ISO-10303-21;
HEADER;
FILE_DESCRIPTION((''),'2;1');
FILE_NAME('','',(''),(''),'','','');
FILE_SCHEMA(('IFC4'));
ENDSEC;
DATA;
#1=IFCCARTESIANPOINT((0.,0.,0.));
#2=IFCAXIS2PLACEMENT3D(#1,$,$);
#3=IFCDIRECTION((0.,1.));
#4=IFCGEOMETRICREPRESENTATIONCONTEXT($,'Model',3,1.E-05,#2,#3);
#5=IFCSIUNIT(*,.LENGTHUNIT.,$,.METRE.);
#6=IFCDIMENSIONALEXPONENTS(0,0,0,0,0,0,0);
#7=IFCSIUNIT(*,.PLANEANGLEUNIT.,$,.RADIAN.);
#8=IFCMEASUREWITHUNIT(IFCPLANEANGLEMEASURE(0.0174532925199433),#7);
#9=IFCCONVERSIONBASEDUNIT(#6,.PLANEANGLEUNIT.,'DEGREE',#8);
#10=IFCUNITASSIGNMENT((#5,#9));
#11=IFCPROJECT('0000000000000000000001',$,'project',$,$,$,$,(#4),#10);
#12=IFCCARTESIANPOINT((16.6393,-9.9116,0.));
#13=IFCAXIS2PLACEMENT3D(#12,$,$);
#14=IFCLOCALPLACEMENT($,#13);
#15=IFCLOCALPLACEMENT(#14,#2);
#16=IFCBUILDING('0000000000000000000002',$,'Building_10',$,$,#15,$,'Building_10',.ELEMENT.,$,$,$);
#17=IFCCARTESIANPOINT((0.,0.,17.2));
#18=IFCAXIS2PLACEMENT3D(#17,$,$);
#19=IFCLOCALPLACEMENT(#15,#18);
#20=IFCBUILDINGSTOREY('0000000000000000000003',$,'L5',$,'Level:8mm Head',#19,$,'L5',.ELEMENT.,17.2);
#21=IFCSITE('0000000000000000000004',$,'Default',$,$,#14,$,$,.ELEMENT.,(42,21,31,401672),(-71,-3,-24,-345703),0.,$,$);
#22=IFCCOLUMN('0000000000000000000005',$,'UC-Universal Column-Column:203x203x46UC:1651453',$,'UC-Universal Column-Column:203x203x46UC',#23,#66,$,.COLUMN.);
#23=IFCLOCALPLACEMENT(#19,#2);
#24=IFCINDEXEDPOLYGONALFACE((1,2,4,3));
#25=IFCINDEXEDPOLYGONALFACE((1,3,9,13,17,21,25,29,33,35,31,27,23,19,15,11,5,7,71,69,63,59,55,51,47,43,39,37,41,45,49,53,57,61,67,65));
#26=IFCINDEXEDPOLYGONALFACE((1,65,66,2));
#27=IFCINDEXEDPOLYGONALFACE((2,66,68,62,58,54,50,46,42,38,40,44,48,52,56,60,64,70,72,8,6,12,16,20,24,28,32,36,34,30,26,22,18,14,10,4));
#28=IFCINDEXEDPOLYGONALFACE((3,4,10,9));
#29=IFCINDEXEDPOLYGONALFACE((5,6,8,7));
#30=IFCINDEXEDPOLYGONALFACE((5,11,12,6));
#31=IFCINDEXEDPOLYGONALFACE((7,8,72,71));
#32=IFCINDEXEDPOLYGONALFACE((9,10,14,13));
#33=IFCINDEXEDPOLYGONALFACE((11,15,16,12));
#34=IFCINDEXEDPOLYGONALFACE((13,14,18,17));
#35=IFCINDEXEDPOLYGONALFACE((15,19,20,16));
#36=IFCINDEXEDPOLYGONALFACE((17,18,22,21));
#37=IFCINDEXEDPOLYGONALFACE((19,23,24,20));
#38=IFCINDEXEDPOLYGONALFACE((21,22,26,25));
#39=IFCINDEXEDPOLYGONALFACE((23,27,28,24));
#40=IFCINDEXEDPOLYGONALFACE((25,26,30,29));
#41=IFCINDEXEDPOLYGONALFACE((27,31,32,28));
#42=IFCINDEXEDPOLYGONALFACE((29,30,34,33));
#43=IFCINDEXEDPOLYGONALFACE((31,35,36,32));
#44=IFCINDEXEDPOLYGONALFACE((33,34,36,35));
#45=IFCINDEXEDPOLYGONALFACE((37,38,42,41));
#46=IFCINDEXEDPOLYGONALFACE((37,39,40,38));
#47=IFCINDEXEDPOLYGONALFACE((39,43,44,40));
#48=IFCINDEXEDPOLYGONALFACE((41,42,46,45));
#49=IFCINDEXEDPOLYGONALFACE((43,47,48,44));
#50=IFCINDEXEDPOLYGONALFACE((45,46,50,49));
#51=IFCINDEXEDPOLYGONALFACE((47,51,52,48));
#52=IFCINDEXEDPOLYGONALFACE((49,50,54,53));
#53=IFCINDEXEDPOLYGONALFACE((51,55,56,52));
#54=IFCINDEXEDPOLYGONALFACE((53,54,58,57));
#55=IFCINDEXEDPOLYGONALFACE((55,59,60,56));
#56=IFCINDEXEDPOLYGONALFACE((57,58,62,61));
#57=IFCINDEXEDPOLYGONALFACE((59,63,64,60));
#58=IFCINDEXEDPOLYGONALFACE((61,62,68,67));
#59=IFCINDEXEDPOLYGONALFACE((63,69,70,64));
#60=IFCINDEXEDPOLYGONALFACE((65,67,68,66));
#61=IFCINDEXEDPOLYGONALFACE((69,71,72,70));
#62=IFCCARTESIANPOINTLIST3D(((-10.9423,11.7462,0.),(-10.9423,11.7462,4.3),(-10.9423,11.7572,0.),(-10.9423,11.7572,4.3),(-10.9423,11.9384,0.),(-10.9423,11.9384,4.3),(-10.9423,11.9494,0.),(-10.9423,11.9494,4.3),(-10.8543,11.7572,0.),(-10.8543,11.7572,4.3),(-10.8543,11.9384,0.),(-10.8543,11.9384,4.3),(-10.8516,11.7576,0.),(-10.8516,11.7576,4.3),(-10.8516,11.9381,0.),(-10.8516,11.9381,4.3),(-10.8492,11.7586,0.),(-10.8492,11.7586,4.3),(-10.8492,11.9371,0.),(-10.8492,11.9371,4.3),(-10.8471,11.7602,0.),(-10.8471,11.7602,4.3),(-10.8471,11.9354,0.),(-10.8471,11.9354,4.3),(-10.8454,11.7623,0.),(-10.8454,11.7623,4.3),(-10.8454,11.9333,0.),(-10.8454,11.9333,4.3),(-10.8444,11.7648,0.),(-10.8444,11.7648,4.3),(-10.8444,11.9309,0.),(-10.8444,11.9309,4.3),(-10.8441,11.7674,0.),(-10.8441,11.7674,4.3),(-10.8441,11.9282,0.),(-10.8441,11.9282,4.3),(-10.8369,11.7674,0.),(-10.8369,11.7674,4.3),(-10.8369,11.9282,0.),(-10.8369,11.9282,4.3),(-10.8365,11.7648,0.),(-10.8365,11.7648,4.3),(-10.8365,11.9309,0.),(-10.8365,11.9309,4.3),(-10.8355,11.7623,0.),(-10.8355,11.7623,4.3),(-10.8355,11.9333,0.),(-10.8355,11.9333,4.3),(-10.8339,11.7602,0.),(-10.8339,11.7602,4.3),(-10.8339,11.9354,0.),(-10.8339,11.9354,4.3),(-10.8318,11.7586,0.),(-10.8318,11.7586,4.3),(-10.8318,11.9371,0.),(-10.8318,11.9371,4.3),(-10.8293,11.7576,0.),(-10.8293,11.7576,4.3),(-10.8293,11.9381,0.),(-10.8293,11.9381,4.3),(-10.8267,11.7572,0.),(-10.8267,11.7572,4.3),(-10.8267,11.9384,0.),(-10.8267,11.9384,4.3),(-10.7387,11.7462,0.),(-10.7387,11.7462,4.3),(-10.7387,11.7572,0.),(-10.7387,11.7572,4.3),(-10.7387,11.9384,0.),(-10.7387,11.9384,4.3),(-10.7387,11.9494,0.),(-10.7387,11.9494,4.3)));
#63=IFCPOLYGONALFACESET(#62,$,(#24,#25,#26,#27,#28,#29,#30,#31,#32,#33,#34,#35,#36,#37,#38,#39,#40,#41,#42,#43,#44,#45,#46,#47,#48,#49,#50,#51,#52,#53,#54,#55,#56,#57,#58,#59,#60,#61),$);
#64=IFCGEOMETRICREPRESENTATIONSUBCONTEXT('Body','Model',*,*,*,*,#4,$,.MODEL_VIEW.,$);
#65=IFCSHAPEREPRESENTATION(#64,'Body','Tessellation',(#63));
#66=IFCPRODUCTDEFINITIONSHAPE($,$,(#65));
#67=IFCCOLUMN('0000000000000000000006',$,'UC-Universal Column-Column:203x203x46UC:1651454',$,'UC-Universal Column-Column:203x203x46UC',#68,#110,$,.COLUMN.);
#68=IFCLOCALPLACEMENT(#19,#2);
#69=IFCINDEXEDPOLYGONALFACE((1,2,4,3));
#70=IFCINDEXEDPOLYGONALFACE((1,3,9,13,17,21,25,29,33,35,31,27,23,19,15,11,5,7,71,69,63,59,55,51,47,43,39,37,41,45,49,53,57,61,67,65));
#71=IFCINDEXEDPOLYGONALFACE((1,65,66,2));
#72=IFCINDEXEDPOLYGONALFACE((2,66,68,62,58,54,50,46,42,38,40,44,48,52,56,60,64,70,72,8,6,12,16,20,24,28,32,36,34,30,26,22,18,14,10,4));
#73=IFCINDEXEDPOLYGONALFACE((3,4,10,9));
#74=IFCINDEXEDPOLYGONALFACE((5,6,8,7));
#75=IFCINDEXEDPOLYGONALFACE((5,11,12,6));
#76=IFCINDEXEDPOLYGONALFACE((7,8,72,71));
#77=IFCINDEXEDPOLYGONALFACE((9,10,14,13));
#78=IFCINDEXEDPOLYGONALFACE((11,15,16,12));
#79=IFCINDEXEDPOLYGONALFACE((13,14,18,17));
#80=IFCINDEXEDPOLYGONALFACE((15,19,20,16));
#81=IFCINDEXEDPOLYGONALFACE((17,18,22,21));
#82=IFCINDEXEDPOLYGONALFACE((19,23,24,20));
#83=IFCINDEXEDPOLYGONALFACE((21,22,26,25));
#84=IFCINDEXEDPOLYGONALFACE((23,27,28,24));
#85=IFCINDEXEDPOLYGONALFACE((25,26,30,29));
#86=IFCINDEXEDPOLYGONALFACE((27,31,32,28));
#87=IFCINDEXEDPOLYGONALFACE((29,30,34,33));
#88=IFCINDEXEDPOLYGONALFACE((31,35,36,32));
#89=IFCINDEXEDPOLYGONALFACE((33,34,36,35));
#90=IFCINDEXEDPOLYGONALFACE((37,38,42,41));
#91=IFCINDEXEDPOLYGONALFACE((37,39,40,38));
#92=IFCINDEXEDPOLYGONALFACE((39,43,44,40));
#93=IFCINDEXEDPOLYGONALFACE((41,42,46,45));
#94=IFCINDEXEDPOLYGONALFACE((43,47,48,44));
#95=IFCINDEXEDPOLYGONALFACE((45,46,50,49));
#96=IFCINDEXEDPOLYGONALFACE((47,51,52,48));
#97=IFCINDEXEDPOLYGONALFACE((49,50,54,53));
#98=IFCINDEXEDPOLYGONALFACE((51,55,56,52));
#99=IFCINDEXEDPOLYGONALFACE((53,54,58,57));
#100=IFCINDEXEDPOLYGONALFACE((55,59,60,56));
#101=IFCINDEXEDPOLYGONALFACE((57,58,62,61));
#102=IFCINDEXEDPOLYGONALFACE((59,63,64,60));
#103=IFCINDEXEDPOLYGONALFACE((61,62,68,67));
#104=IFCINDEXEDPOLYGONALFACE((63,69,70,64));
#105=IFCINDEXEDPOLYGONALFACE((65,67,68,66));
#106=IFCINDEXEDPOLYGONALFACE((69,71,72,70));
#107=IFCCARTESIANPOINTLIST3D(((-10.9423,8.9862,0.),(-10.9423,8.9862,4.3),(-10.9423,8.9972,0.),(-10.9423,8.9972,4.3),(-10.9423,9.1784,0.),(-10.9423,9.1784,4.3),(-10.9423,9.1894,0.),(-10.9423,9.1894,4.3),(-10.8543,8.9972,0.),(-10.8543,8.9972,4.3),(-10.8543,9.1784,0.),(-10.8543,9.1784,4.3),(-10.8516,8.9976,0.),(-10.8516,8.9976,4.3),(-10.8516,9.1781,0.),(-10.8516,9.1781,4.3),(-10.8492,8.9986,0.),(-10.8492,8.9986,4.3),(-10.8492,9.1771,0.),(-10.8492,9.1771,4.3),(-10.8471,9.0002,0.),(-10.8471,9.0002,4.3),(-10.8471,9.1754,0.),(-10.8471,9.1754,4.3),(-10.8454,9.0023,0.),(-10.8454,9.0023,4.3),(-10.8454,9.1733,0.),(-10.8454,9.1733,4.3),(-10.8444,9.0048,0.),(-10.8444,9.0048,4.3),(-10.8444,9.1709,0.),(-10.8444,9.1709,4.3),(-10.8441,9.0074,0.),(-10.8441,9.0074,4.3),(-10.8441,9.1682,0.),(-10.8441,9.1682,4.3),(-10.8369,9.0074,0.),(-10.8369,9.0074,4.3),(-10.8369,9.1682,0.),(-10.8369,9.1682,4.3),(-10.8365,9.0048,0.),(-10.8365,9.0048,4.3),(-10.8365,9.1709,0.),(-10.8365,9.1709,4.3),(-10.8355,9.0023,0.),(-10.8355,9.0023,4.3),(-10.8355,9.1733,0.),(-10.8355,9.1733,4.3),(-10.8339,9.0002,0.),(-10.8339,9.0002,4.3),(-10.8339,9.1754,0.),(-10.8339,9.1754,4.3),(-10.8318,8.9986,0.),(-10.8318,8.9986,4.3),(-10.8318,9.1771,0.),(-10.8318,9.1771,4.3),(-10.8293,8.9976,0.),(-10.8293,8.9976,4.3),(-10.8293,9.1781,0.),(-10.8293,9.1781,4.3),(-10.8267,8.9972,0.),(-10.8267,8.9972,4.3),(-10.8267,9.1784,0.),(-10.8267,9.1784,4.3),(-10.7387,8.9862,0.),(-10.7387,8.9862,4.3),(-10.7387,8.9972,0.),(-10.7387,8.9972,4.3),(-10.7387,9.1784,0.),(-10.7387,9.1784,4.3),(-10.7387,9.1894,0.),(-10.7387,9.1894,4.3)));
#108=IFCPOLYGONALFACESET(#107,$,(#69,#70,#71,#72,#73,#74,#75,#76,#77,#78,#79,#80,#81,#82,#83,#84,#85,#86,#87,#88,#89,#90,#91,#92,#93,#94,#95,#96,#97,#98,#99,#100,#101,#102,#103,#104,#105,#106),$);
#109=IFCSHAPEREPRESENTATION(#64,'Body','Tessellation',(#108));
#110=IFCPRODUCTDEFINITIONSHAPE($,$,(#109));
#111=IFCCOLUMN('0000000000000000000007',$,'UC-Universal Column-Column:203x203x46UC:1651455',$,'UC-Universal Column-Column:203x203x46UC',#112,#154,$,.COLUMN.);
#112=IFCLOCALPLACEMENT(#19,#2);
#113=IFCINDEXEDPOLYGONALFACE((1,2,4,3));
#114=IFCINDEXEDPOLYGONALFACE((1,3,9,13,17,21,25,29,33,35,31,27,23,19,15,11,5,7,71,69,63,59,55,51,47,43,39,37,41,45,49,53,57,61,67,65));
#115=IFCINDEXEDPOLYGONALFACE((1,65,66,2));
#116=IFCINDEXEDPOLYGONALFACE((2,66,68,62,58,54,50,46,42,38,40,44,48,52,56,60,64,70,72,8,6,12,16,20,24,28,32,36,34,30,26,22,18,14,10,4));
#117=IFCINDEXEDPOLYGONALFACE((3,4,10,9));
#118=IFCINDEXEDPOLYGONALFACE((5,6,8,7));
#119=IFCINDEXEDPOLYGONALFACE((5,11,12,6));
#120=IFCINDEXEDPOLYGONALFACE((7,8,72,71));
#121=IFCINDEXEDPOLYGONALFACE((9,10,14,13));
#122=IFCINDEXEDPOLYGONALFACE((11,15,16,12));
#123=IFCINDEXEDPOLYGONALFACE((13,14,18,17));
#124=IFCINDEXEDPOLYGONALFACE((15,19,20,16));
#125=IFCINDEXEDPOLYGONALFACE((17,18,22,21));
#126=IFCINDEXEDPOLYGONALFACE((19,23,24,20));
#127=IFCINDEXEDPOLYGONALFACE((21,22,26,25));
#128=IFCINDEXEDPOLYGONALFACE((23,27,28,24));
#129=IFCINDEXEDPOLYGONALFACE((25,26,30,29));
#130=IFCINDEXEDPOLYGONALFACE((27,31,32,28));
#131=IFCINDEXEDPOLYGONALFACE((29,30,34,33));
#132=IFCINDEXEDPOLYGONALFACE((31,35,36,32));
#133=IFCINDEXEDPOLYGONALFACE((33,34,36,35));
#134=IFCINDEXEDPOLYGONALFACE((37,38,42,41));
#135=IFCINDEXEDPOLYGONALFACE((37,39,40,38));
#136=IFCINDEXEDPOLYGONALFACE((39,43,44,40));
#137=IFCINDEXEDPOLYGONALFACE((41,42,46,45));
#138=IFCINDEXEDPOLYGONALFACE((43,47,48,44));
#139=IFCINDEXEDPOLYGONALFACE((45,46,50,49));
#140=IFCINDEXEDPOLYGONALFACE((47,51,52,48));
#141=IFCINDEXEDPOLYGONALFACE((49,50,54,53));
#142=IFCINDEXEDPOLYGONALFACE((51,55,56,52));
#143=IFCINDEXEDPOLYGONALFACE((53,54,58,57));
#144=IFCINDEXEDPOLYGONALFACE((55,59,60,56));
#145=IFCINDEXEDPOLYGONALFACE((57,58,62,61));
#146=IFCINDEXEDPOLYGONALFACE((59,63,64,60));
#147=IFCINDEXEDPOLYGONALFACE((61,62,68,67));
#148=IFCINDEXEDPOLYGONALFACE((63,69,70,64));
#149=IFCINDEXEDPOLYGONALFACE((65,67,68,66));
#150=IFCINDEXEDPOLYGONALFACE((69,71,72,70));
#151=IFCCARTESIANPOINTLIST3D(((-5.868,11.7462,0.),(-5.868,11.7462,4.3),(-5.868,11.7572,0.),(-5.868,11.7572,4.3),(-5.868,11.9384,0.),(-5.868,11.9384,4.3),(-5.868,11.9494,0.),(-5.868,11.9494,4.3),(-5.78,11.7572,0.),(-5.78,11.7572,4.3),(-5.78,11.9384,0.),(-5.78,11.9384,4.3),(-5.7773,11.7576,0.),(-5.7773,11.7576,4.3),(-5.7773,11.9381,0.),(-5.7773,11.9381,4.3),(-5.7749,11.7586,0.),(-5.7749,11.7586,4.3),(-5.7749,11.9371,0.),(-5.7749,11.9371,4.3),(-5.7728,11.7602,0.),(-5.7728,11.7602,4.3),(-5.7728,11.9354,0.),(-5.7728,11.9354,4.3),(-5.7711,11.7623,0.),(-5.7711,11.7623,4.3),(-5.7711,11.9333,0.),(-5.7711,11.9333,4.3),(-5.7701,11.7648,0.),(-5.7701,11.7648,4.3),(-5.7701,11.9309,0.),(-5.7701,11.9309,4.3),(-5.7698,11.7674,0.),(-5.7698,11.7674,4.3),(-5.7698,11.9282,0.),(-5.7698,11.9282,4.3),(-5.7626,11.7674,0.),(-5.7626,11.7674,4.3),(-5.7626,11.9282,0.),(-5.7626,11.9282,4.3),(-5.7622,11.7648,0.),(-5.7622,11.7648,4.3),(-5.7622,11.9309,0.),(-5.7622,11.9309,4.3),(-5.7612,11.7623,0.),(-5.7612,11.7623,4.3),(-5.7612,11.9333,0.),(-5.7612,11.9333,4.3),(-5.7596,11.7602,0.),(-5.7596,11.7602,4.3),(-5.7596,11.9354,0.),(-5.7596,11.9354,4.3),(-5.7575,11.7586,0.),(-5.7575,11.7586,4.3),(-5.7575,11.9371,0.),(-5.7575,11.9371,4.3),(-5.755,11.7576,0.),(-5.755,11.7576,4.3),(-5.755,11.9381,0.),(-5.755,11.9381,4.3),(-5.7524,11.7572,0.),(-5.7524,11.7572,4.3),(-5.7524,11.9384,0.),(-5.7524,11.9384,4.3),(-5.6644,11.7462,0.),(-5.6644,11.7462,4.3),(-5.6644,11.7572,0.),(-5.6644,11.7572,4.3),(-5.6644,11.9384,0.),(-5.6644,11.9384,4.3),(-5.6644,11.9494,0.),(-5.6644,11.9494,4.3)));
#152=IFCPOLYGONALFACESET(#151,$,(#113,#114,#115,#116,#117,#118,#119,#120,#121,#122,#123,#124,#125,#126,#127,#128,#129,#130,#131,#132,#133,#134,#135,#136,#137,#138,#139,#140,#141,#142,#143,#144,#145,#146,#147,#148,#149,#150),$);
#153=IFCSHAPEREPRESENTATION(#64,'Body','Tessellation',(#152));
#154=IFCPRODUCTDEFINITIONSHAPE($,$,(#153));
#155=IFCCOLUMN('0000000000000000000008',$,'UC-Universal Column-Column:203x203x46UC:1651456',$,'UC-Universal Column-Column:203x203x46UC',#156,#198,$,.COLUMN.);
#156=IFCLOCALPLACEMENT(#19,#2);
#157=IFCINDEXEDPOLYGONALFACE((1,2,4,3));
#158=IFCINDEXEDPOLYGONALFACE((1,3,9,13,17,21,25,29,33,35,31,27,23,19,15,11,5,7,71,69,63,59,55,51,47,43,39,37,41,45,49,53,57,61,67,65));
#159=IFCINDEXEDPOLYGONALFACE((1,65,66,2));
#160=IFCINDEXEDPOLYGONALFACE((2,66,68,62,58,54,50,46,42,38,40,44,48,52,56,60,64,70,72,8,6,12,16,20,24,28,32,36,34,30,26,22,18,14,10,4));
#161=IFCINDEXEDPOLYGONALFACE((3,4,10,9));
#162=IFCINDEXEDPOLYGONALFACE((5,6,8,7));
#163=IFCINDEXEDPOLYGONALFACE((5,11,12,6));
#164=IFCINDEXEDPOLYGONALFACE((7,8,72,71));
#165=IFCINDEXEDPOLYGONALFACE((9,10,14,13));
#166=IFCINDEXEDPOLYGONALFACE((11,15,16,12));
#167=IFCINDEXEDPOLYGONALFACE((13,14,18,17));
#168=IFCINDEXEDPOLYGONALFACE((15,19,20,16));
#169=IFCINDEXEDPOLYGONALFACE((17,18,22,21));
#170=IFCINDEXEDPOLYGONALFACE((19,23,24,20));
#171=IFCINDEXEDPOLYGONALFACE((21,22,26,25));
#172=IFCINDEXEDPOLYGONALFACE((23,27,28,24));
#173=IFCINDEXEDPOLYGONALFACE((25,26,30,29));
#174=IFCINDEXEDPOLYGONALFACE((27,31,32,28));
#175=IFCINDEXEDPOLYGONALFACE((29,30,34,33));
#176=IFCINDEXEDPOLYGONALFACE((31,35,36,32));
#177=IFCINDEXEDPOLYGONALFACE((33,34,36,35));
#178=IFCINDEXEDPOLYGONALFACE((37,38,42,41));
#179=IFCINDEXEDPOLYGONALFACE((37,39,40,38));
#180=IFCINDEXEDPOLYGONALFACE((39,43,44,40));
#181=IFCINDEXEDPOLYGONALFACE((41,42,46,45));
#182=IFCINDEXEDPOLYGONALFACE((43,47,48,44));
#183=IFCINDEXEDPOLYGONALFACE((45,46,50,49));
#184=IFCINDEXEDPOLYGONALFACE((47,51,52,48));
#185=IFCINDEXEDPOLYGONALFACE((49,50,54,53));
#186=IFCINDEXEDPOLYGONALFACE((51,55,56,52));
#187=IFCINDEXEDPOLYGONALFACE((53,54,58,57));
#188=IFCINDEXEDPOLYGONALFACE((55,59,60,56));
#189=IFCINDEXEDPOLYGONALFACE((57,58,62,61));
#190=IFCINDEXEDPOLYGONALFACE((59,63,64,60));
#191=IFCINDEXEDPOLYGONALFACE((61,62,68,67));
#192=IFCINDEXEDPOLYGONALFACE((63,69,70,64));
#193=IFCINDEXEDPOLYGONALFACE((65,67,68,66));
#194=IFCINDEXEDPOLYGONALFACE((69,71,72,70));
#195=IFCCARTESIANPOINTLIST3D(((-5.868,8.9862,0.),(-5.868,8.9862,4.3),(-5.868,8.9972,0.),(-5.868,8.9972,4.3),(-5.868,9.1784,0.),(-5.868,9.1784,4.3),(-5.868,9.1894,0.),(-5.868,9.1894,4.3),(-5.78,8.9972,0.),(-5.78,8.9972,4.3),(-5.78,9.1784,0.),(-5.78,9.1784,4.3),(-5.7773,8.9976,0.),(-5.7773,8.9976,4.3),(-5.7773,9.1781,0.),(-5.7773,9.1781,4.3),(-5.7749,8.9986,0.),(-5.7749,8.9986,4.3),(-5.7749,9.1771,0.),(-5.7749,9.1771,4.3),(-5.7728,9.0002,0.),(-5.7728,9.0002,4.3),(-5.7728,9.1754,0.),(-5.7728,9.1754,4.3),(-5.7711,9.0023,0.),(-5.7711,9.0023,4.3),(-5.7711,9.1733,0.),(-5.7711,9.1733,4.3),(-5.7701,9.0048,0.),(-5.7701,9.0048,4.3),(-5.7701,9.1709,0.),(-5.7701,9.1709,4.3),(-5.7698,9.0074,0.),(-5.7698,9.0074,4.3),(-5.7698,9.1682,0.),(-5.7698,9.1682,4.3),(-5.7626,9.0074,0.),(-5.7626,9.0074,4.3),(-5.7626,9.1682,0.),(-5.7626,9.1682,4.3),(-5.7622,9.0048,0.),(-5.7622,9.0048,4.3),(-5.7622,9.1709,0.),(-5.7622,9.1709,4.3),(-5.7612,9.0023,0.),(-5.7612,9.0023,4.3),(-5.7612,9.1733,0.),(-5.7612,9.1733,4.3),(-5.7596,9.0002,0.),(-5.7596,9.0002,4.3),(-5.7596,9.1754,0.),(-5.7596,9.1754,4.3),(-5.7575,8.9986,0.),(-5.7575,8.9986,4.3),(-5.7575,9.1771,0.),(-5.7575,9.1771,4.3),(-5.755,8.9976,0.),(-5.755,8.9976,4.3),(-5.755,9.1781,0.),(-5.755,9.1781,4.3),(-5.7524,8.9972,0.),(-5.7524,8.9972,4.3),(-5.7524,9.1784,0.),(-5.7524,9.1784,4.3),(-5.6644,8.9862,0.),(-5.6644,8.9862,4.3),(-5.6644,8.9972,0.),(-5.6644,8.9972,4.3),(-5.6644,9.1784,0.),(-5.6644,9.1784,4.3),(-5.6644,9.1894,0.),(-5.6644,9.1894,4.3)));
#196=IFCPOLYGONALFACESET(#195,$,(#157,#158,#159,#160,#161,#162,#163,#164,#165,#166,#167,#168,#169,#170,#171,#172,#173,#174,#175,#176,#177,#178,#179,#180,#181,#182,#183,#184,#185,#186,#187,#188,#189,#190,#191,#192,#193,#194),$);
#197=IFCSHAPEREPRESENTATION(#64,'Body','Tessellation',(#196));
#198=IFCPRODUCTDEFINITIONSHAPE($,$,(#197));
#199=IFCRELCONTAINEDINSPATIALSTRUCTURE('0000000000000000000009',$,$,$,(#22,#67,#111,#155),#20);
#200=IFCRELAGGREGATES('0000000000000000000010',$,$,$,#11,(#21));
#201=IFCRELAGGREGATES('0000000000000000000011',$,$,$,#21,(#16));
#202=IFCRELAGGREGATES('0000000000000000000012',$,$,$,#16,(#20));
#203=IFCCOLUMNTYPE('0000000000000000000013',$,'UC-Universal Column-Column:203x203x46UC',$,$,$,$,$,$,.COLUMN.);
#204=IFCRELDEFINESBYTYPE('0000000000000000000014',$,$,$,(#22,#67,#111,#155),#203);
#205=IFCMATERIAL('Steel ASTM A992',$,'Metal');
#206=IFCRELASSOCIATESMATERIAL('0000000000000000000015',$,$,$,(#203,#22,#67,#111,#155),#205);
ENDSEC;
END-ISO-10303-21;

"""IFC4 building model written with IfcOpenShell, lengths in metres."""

from ifc_helpers import new_model, entity, si_unit, converted_unit, direction, frame, origin, place, context, subcontext, project, spatial, line, arc, indexed_curve, outline, extrude, source, transform, mapped, material, type_object, type_shapes, element, save


model = new_model("IFC4")

# Units and contexts
model_context = context("Model", 3, precision=1e-05, world=origin(), true_north=direction((0.0, 1.0)))
body_context = subcontext(model_context, "Body", "Model", "MODEL_VIEW")
ifc_project = project(units=[si_unit("LENGTHUNIT", "METRE"), converted_unit("PLANEANGLEUNIT", "DEGREE", entity("IfcPlaneAngleMeasure", 0.0174532925199433), si_unit("PLANEANGLEUNIT", "RADIAN"), dimensions=[0, 0, 0, 0, 0, 0, 0])], contexts=[model_context])

# Site, building, storey
site_placement = place(None, frame((16.6393, -9.9116, 0.0)))
site = spatial("IfcSite", under=ifc_project, at=site_placement, Name="Default", CompositionType="ELEMENT", RefLatitude=(42, 21, 31, 401672), RefLongitude=(-71, -3, -24, -345703), RefElevation=0.0)
building_placement = place(site_placement, origin())
building = spatial("IfcBuilding", under=site, at=building_placement, Name="Building_10", LongName="Building_10", CompositionType="ELEMENT")
storey_placement = place(building_placement, frame((0.0, 0.0, 17.2)))
storey = spatial("IfcBuildingStorey", under=building, at=storey_placement, Name="L5", ObjectType="Level:8mm Head", LongName="L5", CompositionType="ELEMENT", Elevation=17.2)

# Columns
ifc_material = material(Name="Steel ASTM A992", Category="Metal")
column_type = type_object("IfcColumnType", Name="UC-Universal Column-Column:203x203x46UC", PredefinedType="COLUMN", material=ifc_material)
shared_shape_1 = source(origin(), body_context, "Body", "SweptSolid", [
    extrude(outline(indexed_curve([(-0.1018, -0.1016), (0.1018, -0.1016), (0.1018, -0.0906), (0.0138, -0.0906), (0.0066, -0.0876), (0.0036, -0.0804), (0.0036, 0.0804), (0.0066, 0.0876), (0.0138, 0.0906), (0.1018, 0.0906), (0.1018, 0.1016), (-0.1018, 0.1016), (-0.1018, 0.0906), (-0.0138, 0.0906), (-0.0066, 0.0876), (-0.0036, 0.0804), (-0.0036, -0.0804), (-0.0066, -0.0876), (-0.0138, -0.0906), (-0.1018, -0.0906)], segments=[line(1, 2, 3, 4), arc(4, 5, 6), line(6, 7), arc(7, 8, 9), line(9, 10, 11, 12, 13, 14), arc(14, 15, 16), line(16, 17), arc(17, 18, 19), line(19, 20, 1)], self_intersect=False)), frame((0.0, 0.0, 17.2), z_axis=(0.0, 0.0, 1.0), x_axis=(-1.0, 0.0, 0.0)), (0.0, 0.0, 1.0), 4.3),
])
type_shapes(column_type, [shared_shape_1])
for number, where, name in (
    (1, (-10.8405, 11.8478, -17.2), "UC-Universal Column-Column:203x203x46UC:1651453"),
    (2, (-10.8405, 9.0878, -17.2), "UC-Universal Column-Column:203x203x46UC:1651454"),
    (3, (-5.7662, 11.8478, -17.2), "UC-Universal Column-Column:203x203x46UC:1651455"),
    (4, (-5.7662, 9.0878, -17.2), "UC-Universal Column-Column:203x203x46UC:1651456"),
):
    element("IfcColumn", number, at=place(storey_placement, frame(where)), inside=storey, type_object=column_type, material=ifc_material, Name=name, ObjectType="UC-Universal Column-Column:203x203x46UC", PredefinedType="COLUMN", context=body_context, shape_type="MappedRepresentation", body=[
        mapped(shared_shape_1, transform((0.0, 0.0, 0.0), scale=1.0)),
    ])

save(model, "model.ifc")
